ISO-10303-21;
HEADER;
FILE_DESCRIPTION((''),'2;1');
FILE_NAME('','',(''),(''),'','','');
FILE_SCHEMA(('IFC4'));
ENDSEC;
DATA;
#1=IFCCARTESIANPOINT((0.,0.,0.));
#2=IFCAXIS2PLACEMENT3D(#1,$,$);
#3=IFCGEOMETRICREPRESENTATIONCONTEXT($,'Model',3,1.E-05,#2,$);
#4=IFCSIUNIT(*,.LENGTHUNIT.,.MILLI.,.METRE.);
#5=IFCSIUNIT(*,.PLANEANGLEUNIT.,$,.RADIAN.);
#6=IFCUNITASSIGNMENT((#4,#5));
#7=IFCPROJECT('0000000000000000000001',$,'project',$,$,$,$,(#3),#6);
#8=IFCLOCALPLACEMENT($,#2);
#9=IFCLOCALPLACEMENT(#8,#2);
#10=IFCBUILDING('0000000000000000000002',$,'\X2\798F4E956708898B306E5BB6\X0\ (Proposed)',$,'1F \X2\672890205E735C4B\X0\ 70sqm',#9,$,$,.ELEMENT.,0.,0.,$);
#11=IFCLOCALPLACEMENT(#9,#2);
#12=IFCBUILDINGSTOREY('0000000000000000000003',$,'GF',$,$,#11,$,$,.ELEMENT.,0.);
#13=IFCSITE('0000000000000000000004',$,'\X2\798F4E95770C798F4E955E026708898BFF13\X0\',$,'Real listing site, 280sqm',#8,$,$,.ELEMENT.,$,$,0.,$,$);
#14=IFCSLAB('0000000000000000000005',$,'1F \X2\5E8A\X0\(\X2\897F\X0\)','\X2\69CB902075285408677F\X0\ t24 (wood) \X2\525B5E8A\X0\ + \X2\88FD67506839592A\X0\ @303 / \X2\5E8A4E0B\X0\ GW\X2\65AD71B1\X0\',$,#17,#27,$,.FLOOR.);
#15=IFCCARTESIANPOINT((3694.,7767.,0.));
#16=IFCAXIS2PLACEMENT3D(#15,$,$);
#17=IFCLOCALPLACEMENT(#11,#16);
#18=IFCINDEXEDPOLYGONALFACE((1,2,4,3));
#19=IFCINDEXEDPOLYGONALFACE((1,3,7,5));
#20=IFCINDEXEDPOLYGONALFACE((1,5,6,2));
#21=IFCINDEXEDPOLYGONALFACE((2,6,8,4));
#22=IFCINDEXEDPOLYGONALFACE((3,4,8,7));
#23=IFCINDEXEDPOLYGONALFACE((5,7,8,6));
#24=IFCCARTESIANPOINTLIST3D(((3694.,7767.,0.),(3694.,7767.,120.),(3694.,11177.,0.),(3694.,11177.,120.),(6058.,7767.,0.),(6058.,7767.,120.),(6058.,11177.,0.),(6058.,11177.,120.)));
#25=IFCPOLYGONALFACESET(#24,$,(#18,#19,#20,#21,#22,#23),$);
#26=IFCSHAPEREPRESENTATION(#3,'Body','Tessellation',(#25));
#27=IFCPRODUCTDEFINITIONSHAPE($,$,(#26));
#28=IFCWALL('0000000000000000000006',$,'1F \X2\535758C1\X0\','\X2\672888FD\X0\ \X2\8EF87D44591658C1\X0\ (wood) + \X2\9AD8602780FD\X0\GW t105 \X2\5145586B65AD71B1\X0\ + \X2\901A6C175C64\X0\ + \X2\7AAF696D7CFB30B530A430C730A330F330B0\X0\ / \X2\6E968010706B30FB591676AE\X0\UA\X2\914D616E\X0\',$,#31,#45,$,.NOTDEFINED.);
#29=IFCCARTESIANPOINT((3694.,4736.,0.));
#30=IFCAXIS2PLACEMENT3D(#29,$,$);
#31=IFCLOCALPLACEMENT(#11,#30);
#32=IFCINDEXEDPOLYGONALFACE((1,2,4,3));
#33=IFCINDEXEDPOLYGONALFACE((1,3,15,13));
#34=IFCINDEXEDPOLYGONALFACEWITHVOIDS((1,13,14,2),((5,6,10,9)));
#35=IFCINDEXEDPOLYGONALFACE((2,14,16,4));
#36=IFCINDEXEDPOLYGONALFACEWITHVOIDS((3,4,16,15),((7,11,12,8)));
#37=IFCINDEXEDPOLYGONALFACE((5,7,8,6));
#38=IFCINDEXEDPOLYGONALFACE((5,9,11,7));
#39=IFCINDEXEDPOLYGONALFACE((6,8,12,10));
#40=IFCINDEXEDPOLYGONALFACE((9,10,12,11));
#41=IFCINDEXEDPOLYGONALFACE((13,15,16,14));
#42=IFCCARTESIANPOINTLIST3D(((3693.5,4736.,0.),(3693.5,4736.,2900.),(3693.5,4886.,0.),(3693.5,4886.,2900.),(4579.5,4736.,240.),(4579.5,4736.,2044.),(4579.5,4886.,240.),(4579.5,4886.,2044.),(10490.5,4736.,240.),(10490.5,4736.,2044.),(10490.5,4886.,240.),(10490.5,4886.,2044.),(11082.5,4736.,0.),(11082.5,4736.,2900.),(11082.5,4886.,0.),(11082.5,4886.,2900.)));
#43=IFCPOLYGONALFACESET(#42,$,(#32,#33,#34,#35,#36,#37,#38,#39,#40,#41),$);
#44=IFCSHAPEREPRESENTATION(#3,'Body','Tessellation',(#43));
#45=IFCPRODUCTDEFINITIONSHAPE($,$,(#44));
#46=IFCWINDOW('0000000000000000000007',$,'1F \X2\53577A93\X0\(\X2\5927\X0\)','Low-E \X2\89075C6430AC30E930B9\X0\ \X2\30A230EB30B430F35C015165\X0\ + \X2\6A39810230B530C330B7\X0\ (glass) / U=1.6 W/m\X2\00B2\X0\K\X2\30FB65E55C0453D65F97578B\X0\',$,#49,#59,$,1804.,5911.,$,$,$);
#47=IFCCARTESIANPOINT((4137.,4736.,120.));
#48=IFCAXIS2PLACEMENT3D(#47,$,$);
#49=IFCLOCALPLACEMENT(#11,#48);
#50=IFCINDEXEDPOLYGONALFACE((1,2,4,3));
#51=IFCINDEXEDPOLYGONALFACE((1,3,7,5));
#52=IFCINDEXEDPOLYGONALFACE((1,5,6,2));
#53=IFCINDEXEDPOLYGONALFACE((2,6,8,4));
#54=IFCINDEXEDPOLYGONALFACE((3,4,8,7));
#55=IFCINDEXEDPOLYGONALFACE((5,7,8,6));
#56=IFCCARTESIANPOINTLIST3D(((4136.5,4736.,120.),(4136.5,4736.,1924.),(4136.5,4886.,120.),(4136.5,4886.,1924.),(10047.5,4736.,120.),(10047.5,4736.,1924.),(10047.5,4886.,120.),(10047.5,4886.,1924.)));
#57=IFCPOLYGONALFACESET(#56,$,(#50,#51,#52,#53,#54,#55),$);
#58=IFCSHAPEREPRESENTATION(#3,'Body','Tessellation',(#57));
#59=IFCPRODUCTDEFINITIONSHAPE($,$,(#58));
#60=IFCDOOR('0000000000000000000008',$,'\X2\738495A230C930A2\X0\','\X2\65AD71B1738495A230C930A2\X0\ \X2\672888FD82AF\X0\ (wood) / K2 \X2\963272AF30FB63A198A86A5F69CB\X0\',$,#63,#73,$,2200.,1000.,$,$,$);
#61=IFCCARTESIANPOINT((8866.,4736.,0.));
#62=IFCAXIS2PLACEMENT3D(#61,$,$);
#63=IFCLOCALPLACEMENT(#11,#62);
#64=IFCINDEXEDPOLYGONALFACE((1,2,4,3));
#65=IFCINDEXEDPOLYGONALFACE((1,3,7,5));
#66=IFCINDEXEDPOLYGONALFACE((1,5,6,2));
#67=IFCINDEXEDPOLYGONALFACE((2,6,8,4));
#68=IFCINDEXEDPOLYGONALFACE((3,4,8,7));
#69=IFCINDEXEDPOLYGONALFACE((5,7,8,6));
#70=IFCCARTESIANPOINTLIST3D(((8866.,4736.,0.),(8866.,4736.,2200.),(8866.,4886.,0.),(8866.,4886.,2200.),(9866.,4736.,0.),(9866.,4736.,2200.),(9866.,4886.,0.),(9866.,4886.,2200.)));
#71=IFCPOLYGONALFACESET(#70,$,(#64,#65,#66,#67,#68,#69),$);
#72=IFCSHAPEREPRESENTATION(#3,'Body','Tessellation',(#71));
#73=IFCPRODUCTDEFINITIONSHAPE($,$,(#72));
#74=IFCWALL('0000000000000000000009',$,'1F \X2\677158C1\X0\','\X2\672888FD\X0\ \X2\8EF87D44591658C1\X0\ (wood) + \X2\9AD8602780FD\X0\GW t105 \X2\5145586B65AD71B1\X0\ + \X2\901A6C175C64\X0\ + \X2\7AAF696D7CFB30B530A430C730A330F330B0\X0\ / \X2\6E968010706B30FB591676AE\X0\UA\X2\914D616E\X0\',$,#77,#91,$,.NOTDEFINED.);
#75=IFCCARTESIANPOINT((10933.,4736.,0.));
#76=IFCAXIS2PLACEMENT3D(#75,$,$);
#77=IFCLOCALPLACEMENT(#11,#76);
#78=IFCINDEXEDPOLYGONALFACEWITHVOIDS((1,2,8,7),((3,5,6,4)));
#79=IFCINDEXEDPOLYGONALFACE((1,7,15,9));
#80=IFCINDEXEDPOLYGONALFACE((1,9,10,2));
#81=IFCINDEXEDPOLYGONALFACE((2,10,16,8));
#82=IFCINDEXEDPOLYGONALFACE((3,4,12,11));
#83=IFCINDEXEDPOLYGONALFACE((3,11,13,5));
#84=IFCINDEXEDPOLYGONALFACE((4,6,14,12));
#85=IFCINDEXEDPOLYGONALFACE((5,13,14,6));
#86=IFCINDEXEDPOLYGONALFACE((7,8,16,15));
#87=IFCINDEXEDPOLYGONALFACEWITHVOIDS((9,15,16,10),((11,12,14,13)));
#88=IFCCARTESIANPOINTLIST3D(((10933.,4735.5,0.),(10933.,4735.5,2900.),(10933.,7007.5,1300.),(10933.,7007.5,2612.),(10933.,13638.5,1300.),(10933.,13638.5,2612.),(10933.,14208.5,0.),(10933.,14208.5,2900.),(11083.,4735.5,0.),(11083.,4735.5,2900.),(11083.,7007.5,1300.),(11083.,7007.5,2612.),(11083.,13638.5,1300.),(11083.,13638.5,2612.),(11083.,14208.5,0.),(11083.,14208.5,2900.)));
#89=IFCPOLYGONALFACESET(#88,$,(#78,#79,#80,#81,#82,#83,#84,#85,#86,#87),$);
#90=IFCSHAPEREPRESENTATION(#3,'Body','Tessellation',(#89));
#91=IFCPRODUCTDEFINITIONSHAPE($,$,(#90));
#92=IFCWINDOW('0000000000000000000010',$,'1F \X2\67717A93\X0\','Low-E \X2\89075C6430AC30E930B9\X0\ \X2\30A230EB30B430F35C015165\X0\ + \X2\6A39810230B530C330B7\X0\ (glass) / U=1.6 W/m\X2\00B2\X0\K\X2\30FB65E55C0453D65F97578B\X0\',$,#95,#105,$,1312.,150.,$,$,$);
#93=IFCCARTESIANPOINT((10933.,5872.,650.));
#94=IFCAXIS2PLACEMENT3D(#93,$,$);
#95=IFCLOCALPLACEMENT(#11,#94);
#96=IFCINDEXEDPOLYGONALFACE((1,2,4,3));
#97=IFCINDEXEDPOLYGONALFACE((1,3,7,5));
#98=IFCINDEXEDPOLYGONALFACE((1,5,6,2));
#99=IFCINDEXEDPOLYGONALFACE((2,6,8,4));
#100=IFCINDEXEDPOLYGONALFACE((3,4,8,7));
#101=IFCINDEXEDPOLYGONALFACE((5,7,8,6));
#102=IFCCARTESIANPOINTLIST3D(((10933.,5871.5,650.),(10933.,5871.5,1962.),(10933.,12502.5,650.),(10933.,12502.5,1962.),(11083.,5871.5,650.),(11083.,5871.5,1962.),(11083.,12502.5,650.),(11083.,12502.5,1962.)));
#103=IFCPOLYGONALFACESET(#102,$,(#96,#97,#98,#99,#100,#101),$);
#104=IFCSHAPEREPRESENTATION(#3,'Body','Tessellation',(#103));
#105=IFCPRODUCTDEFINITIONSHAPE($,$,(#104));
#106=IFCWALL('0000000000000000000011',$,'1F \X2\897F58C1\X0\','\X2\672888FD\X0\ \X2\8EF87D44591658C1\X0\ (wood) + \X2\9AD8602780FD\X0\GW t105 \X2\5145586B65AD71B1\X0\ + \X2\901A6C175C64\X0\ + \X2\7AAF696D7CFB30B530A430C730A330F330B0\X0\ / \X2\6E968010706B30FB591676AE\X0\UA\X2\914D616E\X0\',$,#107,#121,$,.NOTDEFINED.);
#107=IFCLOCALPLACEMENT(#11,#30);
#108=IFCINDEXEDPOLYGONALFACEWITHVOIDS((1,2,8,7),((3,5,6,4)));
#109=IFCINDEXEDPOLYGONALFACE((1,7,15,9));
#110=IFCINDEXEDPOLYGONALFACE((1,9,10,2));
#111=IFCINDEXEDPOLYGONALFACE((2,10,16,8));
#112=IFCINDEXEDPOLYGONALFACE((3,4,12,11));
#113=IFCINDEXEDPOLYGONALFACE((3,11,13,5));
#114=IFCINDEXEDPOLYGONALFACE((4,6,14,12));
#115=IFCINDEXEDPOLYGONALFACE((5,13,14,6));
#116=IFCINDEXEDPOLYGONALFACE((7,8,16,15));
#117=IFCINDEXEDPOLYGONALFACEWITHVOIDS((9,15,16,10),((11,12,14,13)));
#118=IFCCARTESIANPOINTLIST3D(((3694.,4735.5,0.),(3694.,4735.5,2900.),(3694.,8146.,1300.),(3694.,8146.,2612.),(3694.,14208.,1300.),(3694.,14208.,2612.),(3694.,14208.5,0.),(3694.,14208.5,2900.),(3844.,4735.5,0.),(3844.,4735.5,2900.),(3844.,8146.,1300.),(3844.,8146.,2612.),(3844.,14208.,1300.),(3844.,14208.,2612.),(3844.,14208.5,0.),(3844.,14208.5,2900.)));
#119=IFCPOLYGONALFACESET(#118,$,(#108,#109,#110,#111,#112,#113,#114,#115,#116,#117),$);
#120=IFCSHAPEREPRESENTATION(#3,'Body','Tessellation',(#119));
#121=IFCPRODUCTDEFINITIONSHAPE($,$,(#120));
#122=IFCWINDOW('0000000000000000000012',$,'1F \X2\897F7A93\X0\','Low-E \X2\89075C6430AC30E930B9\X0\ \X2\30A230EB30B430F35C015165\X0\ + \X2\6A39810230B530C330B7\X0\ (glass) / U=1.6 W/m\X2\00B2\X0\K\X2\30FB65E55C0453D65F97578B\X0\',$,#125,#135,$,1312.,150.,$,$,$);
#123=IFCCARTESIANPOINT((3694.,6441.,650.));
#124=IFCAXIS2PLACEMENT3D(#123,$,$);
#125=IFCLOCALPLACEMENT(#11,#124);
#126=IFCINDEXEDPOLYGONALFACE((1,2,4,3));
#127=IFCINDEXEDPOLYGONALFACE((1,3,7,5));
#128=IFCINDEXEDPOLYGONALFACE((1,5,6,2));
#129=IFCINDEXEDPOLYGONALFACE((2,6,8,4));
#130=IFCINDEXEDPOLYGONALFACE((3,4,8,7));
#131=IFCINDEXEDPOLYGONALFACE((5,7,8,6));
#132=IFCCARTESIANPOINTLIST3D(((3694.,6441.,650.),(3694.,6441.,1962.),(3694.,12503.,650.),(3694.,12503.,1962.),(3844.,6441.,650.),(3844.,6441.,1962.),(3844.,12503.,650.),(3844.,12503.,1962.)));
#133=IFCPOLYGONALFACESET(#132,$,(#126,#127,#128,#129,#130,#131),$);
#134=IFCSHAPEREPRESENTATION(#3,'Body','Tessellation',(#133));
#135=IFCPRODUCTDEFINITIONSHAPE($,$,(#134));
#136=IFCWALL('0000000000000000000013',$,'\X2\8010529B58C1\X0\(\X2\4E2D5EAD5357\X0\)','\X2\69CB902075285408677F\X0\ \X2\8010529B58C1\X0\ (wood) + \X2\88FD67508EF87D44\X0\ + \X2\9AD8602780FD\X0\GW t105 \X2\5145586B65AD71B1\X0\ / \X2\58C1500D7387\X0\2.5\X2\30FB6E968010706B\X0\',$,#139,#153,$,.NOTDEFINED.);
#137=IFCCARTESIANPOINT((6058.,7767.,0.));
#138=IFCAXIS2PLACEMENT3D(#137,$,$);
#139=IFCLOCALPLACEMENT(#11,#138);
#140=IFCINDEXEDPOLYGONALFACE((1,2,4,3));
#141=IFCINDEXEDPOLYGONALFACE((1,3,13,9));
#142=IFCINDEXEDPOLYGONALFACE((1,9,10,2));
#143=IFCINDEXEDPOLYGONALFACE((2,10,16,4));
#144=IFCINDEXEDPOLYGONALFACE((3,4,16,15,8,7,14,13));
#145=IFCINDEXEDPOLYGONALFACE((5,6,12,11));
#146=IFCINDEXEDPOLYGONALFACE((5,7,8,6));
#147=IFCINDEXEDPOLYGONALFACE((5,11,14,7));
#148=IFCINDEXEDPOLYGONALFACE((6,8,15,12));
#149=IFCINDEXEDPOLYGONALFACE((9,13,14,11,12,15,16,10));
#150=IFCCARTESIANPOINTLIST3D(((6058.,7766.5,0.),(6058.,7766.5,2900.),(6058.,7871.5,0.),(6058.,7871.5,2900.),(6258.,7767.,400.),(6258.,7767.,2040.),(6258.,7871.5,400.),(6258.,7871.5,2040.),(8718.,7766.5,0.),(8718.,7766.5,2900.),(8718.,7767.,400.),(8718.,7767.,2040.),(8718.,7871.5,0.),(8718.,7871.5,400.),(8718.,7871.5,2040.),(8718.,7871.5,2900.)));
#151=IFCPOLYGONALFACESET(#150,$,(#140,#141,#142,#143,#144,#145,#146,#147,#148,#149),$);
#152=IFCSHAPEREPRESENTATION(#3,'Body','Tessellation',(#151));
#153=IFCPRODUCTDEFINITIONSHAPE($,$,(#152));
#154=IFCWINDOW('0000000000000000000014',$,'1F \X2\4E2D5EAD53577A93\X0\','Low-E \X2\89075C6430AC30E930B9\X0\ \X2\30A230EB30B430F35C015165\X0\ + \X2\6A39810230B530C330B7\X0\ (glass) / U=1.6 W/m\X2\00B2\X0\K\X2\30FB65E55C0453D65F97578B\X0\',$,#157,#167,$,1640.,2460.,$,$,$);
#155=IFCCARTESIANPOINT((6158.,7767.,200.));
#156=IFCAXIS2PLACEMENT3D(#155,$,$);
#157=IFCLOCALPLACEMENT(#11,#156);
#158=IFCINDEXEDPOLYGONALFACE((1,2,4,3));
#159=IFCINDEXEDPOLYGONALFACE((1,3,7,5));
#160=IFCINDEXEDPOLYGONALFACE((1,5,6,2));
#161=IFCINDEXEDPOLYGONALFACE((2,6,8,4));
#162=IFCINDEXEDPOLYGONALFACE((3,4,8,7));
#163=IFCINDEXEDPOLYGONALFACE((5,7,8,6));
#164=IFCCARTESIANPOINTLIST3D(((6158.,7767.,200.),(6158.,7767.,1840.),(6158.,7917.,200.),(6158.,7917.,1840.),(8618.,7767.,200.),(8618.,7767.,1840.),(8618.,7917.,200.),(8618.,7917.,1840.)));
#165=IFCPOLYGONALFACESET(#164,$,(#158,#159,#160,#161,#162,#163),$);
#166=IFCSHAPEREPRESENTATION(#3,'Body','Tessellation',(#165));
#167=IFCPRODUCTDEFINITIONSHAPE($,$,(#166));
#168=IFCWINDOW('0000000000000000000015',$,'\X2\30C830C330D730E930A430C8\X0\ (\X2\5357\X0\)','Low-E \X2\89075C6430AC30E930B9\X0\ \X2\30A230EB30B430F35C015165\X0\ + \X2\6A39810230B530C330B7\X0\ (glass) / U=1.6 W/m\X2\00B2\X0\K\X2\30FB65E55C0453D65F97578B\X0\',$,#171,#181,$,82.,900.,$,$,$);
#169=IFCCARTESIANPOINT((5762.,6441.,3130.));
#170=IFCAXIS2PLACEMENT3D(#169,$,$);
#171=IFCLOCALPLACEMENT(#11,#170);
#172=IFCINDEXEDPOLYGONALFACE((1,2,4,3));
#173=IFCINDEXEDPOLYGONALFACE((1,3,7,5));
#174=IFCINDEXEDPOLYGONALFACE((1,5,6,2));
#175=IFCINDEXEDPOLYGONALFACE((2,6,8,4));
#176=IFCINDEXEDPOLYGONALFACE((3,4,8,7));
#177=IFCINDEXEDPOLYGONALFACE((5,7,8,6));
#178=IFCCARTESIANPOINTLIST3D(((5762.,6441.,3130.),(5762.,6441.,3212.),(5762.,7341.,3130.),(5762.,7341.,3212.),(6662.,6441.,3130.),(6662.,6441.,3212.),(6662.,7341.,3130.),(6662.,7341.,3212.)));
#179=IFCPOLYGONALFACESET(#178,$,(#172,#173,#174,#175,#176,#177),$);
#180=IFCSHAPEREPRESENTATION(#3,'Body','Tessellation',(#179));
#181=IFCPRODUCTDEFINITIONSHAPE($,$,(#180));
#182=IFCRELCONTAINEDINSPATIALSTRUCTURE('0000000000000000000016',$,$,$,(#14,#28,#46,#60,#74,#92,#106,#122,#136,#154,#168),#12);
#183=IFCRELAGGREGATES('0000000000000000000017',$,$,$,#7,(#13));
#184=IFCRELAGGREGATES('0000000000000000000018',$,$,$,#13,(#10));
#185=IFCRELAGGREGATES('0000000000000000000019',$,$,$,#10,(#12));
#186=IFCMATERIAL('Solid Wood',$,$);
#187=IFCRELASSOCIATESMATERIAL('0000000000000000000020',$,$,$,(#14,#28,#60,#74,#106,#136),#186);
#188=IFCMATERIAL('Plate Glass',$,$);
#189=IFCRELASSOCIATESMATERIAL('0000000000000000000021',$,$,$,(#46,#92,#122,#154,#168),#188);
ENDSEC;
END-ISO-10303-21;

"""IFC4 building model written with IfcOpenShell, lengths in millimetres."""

from ifc_helpers import new_model, si_unit, frame, frame_2d, origin, place, context, project, spatial, rectangle, extrude, material, element, fill, save


model = new_model("IFC4")

# Units and contexts
model_context = context("Model", 3, precision=1e-05, world=origin())
ifc_project = project(units=[si_unit("LENGTHUNIT", "METRE", prefix="MILLI"), si_unit("PLANEANGLEUNIT", "RADIAN")], contexts=[model_context])

# Site, building, storey
site_placement = place(None, origin())
site = spatial("IfcSite", under=ifc_project, at=site_placement, Name="福井県福井市月見３", ObjectType="Real listing site, 280sqm", CompositionType="ELEMENT", RefElevation=0.0)
building_placement = place(site_placement, origin())
building = spatial("IfcBuilding", under=site, at=building_placement, Name="福井月見の家 (Proposed)", ObjectType="1F 木造平屋 70sqm", CompositionType="ELEMENT", ElevationOfRefHeight=0.0, ElevationOfTerrain=0.0)
storey_placement = place(building_placement, origin())
storey = spatial("IfcBuildingStorey", under=building, at=storey_placement, Name="GF", CompositionType="ELEMENT", Elevation=0.0)

# Slab
ifc_material_1 = material(Name="Solid Wood")
slab_1_placement = place(storey_placement, frame((3694.0, 7767.0, 0.0)))
element("IfcSlab", 1, at=slab_1_placement, inside=storey, material=ifc_material_1, Name="1F 床(西)", Description="構造用合板 t24 (wood) 剛床 + 製材根太 @303 / 床下 GW断熱", PredefinedType="FLOOR", context=model_context, shape_type="SweptSolid", body=[
    extrude(rectangle(XDim=2364.0, YDim=3410.0, at=frame_2d((1182.0, 1705.0))), frame((3694.0, 7767.0, 0.0)), (0.0, 0.0, 1.0), 120.0),
])

# Wall, openings, window, door
wall_1_placement = place(storey_placement, frame((3694.0, 4736.0, 0.0)))
wall_1 = element("IfcWall", 2, at=wall_1_placement, inside=storey, material=ifc_material_1, Name="1F 南壁", Description="木製 軸組外壁 (wood) + 高性能GW t105 充填断熱 + 通気層 + 窯業系サイディング / 準耐火・外皮UA配慮", PredefinedType="NOTDEFINED", context=model_context, shape_type="SweptSolid", body=[
    extrude(rectangle(XDim=7389.0, YDim=150.0, at=frame_2d((3694.0, 75.0))), frame((3694.0, 4736.0, 0.0)), (0.0, 0.0, 1.0), 2900.0),
])
opening_1_placement = place(storey_placement, frame((4137.0, 4736.0, 120.0)))
opening_1 = element("IfcOpeningElement", 3, at=opening_1_placement, cuts=wall_1, PredefinedType="NOTDEFINED", context=model_context, shape_type="SweptSolid", body=[
    extrude(rectangle(XDim=5911.0, YDim=150.0, at=frame_2d((2955.0, 75.0))), frame((4137.0, 4736.0, 120.0)), (0.0, 0.0, 1.0), 1804.0),
])
opening_2_placement = place(storey_placement, frame((8866.0, 4736.0, 0.0)))
opening_2 = element("IfcOpeningElement", 4, at=opening_2_placement, cuts=wall_1, PredefinedType="NOTDEFINED", context=model_context, shape_type="SweptSolid", body=[
    extrude(rectangle(XDim=1000.0, YDim=150.0, at=frame_2d((500.0, 75.0))), frame((8866.0, 4736.0, 0.0)), (0.0, 0.0, 1.0), 2200.0),
])
ifc_material_2 = material(Name="Plate Glass")
window_1_placement = place(storey_placement, frame((4137.0, 4736.0, 120.0)))
window_1 = element("IfcWindow", 5, at=window_1_placement, inside=storey, material=ifc_material_2, Name="1F 南窓(大)", Description="Low-E 複層ガラス アルゴン封入 + 樹脂サッシ (glass) / U=1.6 W/m²K・日射取得型", OverallHeight=1804.0, OverallWidth=5911.0, context=model_context, shape_type="SweptSolid", body=[
    extrude(rectangle(XDim=5911.0, YDim=150.0, at=frame_2d((2955.0, 75.0))), frame((4137.0, 4736.0, 120.0)), (0.0, 0.0, 1.0), 1804.0),
])
fill(opening_1, window_1)
door_placement = place(storey_placement, frame((8866.0, 4736.0, 0.0)))
door = element("IfcDoor", 6, at=door_placement, inside=storey, material=ifc_material_1, Name="玄関ドア", Description="断熱玄関ドア 木製芯 (wood) / K2 防犯・採風機構", OverallHeight=2200.0, OverallWidth=1000.0, context=model_context, shape_type="SweptSolid", body=[
    extrude(rectangle(XDim=1000.0, YDim=150.0, at=frame_2d((500.0, 75.0))), frame((8866.0, 4736.0, 0.0)), (0.0, 0.0, 1.0), 2200.0),
])
fill(opening_2, door)

# Walls, openings, windows
wall_2_placement = place(storey_placement, frame((10933.0, 4736.0, 0.0)))
wall_2 = element("IfcWall", 7, at=wall_2_placement, inside=storey, material=ifc_material_1, Name="1F 東壁", Description="木製 軸組外壁 (wood) + 高性能GW t105 充填断熱 + 通気層 + 窯業系サイディング / 準耐火・外皮UA配慮", PredefinedType="NOTDEFINED", context=model_context, shape_type="SweptSolid", body=[
    extrude(rectangle(XDim=150.0, YDim=9473.0, at=frame_2d((75.0, 4736.0))), frame((10933.0, 4736.0, 0.0)), (0.0, 0.0, 1.0), 2900.0),
])
opening_3_placement = place(storey_placement, frame((10933.0, 5872.0, 650.0)))
opening_3 = element("IfcOpeningElement", 8, at=opening_3_placement, cuts=wall_2, PredefinedType="NOTDEFINED", context=model_context, shape_type="SweptSolid", body=[
    extrude(rectangle(XDim=150.0, YDim=6631.0, at=frame_2d((75.0, 3315.0))), frame((10933.0, 5872.0, 650.0)), (0.0, 0.0, 1.0), 1312.0),
])
window_2_placement = place(storey_placement, frame((10933.0, 5872.0, 650.0)))
window_2 = element("IfcWindow", 9, at=window_2_placement, inside=storey, material=ifc_material_2, Name="1F 東窓", Description="Low-E 複層ガラス アルゴン封入 + 樹脂サッシ (glass) / U=1.6 W/m²K・日射取得型", OverallHeight=1312.0, OverallWidth=150.0, context=model_context, shape_type="SweptSolid", body=[
    extrude(rectangle(XDim=150.0, YDim=6631.0, at=frame_2d((75.0, 3315.0))), frame((10933.0, 5872.0, 650.0)), (0.0, 0.0, 1.0), 1312.0),
])
fill(opening_3, window_2)
wall_3_placement = place(storey_placement, frame((3694.0, 4736.0, 0.0)))
wall_3 = element("IfcWall", 10, at=wall_3_placement, inside=storey, material=ifc_material_1, Name="1F 西壁", Description="木製 軸組外壁 (wood) + 高性能GW t105 充填断熱 + 通気層 + 窯業系サイディング / 準耐火・外皮UA配慮", PredefinedType="NOTDEFINED", context=model_context, shape_type="SweptSolid", body=[
    extrude(rectangle(XDim=150.0, YDim=9473.0, at=frame_2d((75.0, 4736.0))), frame((3694.0, 4736.0, 0.0)), (0.0, 0.0, 1.0), 2900.0),
])
opening_4_placement = place(storey_placement, frame((3694.0, 6441.0, 650.0)))
opening_4 = element("IfcOpeningElement", 11, at=opening_4_placement, cuts=wall_3, PredefinedType="NOTDEFINED", context=model_context, shape_type="SweptSolid", body=[
    extrude(rectangle(XDim=150.0, YDim=6062.0, at=frame_2d((75.0, 3031.0))), frame((3694.0, 6441.0, 650.0)), (0.0, 0.0, 1.0), 1312.0),
])
window_3_placement = place(storey_placement, frame((3694.0, 6441.0, 650.0)))
window_3 = element("IfcWindow", 12, at=window_3_placement, inside=storey, material=ifc_material_2, Name="1F 西窓", Description="Low-E 複層ガラス アルゴン封入 + 樹脂サッシ (glass) / U=1.6 W/m²K・日射取得型", OverallHeight=1312.0, OverallWidth=150.0, context=model_context, shape_type="SweptSolid", body=[
    extrude(rectangle(XDim=150.0, YDim=6062.0, at=frame_2d((75.0, 3031.0))), frame((3694.0, 6441.0, 650.0)), (0.0, 0.0, 1.0), 1312.0),
])
fill(opening_4, window_3)
wall_4_placement = place(storey_placement, frame((6058.0, 7767.0, 0.0)))
wall_4 = element("IfcWall", 13, at=wall_4_placement, inside=storey, material=ifc_material_1, Name="耐力壁(中庭南)", Description="構造用合板 耐力壁 (wood) + 製材軸組 + 高性能GW t105 充填断熱 / 壁倍率2.5・準耐火", PredefinedType="NOTDEFINED", context=model_context, shape_type="SweptSolid", body=[
    extrude(rectangle(XDim=2660.0, YDim=105.0, at=frame_2d((1330.0, 52.0))), frame((6058.0, 7767.0, 0.0)), (0.0, 0.0, 1.0), 2900.0),
])
opening_5_placement = place(storey_placement, frame((6158.0, 7767.0, 200.0)))
opening_5 = element("IfcOpeningElement", 14, at=opening_5_placement, cuts=wall_4, PredefinedType="NOTDEFINED", context=model_context, shape_type="SweptSolid", body=[
    extrude(rectangle(XDim=2460.0, YDim=150.0, at=frame_2d((1230.0, 75.0))), frame((6158.0, 7767.0, 200.0)), (0.0, 0.0, 1.0), 1640.0),
])
window_4_placement = place(storey_placement, frame((6158.0, 7767.0, 200.0)))
window_4 = element("IfcWindow", 15, at=window_4_placement, inside=storey, material=ifc_material_2, Name="1F 中庭南窓", Description="Low-E 複層ガラス アルゴン封入 + 樹脂サッシ (glass) / U=1.6 W/m²K・日射取得型", OverallHeight=1640.0, OverallWidth=2460.0, context=model_context, shape_type="SweptSolid", body=[
    extrude(rectangle(XDim=2460.0, YDim=150.0, at=frame_2d((1230.0, 75.0))), frame((6158.0, 7767.0, 200.0)), (0.0, 0.0, 1.0), 1640.0),
])
fill(opening_5, window_4)

# Window
window_5_placement = place(storey_placement, frame((5762.0, 6441.0, 3130.0)))
element("IfcWindow", 16, at=window_5_placement, inside=storey, material=ifc_material_2, Name="トップライト (南)", Description="Low-E 複層ガラス アルゴン封入 + 樹脂サッシ (glass) / U=1.6 W/m²K・日射取得型", OverallHeight=82.0, OverallWidth=900.0, context=model_context, shape_type="SweptSolid", body=[
    extrude(rectangle(XDim=900.0, YDim=900.0, at=frame_2d((450.0, 450.0))), frame((5762.0, 6441.0, 3130.0)), (0.0, 0.0, 1.0), 82.0),
])

save(model, "model.ifc")
